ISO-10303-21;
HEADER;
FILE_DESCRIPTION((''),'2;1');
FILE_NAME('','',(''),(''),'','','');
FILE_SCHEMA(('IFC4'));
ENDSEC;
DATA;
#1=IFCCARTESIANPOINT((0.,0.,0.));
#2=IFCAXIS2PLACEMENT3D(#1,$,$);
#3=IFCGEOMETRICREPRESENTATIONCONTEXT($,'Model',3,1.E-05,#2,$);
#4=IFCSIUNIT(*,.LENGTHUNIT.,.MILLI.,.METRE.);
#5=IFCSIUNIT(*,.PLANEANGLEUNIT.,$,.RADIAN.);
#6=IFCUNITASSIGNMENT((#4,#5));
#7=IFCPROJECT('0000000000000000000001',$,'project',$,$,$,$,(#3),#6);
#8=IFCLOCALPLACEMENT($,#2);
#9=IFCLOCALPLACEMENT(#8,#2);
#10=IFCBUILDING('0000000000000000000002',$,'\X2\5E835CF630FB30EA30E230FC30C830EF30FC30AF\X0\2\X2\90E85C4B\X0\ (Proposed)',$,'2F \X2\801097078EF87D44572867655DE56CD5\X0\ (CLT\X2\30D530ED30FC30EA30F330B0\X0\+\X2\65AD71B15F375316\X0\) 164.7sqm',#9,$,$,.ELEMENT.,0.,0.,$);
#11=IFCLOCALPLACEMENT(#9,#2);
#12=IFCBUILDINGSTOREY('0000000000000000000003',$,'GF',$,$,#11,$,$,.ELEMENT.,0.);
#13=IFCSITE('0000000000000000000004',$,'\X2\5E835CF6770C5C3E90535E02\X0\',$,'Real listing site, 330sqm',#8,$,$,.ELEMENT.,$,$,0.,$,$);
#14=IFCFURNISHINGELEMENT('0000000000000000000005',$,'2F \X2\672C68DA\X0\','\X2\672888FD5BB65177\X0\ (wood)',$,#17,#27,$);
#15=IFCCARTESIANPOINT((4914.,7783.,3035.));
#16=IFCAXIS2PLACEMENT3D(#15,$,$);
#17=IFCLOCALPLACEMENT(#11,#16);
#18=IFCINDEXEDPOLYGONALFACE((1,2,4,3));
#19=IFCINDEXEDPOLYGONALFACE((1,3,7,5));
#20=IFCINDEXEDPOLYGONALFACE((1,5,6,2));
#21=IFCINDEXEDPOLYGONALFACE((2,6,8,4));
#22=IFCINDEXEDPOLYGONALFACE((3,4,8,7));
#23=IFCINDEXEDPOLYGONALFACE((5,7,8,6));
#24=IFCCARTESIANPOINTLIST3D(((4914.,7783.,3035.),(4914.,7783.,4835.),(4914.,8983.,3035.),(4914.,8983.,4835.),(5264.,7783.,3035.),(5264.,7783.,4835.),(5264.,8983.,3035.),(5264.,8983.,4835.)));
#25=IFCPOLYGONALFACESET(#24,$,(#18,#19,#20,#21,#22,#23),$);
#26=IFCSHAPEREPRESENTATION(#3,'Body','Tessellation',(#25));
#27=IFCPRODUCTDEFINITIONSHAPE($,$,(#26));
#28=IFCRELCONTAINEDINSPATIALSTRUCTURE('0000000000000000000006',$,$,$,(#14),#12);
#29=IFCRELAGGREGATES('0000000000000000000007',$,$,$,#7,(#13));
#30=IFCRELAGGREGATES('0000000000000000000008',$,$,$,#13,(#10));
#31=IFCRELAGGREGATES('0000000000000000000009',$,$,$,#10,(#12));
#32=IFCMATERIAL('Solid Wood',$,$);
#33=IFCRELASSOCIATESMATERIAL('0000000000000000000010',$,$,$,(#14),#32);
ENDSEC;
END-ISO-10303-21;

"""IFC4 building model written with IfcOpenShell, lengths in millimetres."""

from ifc_helpers import new_model, si_unit, frame, frame_2d, origin, place, context, project, spatial, rectangle, extrude, material, element, save


model = new_model("IFC4")

# Units and contexts
model_context = context("Model", 3, precision=1e-05, world=origin())
ifc_project = project(units=[si_unit("LENGTHUNIT", "METRE", prefix="MILLI"), si_unit("PLANEANGLEUNIT", "RADIAN")], contexts=[model_context])

# Site, building, storey
site_placement = place(None, origin())
site = spatial("IfcSite", under=ifc_project, at=site_placement, Name="広島県尾道市", ObjectType="Real listing site, 330sqm", CompositionType="ELEMENT", RefElevation=0.0)
building_placement = place(site_placement, origin())
building = spatial("IfcBuilding", under=site, at=building_placement, Name="広島・リモートワーク2部屋 (Proposed)", ObjectType="2F 耐震軸組在来工法 (CLTフローリング+断熱強化) 164.7sqm", CompositionType="ELEMENT", ElevationOfRefHeight=0.0, ElevationOfTerrain=0.0)
storey_placement = place(building_placement, origin())
storey = spatial("IfcBuildingStorey", under=building, at=storey_placement, Name="GF", CompositionType="ELEMENT", Elevation=0.0)

# Shared definitions
ifc_material_1 = material(Name="Solid Wood")

# Furnishing element
furnishing_placement = place(storey_placement, frame((4914.0, 7783.0, 3035.0)))
element("IfcFurnishingElement", 1, at=furnishing_placement, inside=storey, material=ifc_material_1, Name="2F 本棚", Description="木製家具 (wood)", context=model_context, shape_type="SweptSolid", body=[
    extrude(rectangle(XDim=350.0, YDim=1200.0, at=frame_2d((175.0, 600.0))), frame((4914.0, 7783.0, 3035.0)), (0.0, 0.0, 1.0), 1800.0),
])

save(model, "model.ifc")
